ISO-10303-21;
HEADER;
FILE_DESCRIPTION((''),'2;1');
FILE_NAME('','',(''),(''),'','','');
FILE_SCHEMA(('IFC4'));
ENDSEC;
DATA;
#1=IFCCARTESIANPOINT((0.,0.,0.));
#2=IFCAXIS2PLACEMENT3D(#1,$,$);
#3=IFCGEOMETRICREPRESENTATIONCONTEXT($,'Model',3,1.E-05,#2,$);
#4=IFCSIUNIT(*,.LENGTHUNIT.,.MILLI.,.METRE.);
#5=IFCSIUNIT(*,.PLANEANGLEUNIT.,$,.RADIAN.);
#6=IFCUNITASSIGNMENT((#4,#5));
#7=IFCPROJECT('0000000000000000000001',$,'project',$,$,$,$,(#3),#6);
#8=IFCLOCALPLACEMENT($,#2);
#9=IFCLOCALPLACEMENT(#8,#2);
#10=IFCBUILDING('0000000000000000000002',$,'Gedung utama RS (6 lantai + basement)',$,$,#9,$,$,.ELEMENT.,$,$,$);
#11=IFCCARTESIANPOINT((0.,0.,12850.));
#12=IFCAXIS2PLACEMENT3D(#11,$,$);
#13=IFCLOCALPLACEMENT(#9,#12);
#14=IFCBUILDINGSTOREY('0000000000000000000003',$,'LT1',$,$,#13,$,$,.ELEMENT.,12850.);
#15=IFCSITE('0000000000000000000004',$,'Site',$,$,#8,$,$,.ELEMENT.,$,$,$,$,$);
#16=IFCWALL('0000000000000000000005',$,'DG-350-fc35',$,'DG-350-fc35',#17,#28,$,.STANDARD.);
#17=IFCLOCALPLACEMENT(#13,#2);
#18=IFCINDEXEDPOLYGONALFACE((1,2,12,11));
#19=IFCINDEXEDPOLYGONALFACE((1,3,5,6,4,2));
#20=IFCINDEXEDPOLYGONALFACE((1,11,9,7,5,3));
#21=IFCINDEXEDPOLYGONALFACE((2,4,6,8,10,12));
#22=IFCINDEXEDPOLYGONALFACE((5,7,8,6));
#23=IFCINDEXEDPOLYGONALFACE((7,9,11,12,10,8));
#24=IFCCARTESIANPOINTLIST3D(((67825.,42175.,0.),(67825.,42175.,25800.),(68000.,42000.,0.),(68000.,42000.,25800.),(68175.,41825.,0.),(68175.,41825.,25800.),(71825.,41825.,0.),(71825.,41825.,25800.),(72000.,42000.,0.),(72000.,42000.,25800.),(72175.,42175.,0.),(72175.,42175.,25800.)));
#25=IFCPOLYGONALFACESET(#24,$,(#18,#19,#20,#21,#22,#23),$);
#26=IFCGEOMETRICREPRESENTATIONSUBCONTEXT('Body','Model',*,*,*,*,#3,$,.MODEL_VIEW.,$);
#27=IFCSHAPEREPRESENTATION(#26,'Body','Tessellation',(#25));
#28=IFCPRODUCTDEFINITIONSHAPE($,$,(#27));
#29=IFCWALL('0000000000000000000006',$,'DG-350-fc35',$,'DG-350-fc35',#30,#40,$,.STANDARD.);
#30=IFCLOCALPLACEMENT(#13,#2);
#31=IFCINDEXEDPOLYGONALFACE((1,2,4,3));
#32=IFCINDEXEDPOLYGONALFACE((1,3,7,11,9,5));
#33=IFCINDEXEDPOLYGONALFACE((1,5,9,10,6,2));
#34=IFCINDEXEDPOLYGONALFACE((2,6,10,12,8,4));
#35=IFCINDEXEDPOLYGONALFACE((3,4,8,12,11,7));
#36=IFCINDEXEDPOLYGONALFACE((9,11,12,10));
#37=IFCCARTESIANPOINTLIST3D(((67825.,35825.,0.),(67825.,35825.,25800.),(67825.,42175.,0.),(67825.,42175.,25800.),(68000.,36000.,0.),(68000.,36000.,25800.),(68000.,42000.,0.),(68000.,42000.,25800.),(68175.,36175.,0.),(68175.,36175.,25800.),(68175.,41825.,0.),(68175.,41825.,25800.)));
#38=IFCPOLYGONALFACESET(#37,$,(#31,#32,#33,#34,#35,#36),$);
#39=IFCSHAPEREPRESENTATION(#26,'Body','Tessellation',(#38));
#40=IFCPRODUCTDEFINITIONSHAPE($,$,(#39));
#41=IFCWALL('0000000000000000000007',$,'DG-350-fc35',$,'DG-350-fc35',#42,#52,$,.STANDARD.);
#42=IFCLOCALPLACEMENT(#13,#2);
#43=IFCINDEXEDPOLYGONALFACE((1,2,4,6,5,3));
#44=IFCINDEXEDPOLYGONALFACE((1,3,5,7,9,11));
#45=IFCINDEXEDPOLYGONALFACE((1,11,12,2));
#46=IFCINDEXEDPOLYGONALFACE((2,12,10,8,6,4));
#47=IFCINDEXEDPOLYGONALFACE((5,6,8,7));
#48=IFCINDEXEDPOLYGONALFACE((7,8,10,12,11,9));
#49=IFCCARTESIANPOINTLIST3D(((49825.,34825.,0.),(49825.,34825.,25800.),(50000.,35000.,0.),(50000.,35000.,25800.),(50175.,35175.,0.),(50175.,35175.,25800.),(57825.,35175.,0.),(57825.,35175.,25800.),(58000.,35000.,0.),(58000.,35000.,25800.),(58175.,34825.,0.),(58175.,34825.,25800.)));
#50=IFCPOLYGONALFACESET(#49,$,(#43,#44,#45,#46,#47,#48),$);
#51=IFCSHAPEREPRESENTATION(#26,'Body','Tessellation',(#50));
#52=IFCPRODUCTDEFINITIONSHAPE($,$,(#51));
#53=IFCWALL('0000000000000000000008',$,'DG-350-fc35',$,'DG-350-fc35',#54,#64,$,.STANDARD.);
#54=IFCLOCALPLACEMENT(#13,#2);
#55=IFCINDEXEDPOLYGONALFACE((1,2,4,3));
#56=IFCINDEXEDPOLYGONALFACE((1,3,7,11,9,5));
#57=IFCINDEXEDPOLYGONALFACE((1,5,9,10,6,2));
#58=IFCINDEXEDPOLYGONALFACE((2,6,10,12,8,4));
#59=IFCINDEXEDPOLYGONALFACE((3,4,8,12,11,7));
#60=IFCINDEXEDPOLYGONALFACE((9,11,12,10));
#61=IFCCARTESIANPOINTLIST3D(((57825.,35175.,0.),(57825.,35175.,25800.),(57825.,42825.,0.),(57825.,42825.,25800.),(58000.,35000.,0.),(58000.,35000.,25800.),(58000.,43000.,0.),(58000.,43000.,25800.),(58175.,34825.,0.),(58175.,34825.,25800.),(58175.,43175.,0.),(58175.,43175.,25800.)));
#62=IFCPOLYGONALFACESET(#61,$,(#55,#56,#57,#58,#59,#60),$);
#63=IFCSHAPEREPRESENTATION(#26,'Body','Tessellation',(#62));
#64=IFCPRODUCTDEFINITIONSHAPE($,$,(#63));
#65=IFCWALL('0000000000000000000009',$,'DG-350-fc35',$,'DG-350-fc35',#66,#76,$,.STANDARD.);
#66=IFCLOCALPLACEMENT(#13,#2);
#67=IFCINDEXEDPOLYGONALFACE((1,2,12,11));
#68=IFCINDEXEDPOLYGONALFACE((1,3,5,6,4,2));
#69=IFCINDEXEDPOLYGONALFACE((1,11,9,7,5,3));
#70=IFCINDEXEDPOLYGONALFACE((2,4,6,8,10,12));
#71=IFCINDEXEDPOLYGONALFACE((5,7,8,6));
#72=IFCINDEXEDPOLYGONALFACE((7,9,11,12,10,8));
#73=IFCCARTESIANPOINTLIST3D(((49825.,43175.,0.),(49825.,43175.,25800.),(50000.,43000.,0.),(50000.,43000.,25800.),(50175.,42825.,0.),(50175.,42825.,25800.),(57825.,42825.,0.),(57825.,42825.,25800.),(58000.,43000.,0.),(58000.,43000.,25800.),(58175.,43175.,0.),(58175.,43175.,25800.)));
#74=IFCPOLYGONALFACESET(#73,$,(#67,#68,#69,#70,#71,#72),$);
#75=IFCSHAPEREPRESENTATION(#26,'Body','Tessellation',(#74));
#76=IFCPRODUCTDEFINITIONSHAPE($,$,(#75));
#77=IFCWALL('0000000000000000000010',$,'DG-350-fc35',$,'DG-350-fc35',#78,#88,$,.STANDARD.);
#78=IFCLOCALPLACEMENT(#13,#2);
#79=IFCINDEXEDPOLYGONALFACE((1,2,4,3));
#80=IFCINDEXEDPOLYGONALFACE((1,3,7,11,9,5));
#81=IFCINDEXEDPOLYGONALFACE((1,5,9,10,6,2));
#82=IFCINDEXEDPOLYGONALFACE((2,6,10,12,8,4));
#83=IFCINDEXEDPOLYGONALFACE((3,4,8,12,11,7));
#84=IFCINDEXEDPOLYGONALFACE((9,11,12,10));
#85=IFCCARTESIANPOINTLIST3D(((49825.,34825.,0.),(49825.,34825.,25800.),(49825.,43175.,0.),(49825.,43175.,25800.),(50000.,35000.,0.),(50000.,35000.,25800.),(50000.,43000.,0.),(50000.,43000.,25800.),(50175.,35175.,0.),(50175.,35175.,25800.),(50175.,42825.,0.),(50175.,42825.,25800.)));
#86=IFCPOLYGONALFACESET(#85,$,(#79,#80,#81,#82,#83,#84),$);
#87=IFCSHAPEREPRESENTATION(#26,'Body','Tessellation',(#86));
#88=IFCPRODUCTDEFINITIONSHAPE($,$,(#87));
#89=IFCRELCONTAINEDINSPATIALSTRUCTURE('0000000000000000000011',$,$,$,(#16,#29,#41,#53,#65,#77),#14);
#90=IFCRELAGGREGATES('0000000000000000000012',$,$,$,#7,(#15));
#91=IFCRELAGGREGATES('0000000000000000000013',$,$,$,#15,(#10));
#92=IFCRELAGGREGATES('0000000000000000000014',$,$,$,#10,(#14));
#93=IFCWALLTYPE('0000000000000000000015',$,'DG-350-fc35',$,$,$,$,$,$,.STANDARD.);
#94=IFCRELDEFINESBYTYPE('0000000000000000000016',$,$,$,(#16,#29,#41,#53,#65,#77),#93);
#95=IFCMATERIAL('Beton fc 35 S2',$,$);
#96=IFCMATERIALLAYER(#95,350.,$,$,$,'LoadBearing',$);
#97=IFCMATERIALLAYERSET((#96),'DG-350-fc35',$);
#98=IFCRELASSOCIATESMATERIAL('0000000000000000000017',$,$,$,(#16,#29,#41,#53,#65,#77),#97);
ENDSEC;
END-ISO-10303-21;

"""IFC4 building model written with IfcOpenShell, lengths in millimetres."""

from ifc_helpers import new_model, si_unit, frame, origin, place, context, subcontext, project, spatial, polyline, outline, extrude, material, layer, layer_set, layer_usage, type_object, element, save


model = new_model("IFC4")

# Units and contexts
model_context = context("Model", 3, precision=1e-05, world=origin())
body_context = subcontext(model_context, "Body", "Model", "MODEL_VIEW")
ifc_project = project(units=[si_unit("LENGTHUNIT", "METRE", prefix="MILLI"), si_unit("PLANEANGLEUNIT", "RADIAN")], contexts=[model_context])

# Site, building, storey
site_placement = place(None, origin())
site = spatial("IfcSite", under=ifc_project, at=site_placement, Name="Site", CompositionType="ELEMENT")
building_placement = place(site_placement, origin())
building = spatial("IfcBuilding", under=site, at=building_placement, Name="Gedung utama RS (6 lantai + basement)", CompositionType="ELEMENT")
storey_placement = place(building_placement, frame((0.0, 0.0, 12850.0)))
storey = spatial("IfcBuildingStorey", under=building, at=storey_placement, Name="LT1", CompositionType="ELEMENT", Elevation=12850.0)

# Walls
ifc_material = material(Name="Beton fc 35 S2")
ifc_layer = layer(ifc_material, 350.0, Category="LoadBearing")
ifc_layer_set = layer_set([ifc_layer], Name="DG-350-fc35")
ifc_layer_usage = layer_usage(ifc_layer_set, "AXIS2", "NEGATIVE", 175.0)
wall_type = type_object("IfcWallType", Name="DG-350-fc35", PredefinedType="STANDARD")
wall_1_placement = place(storey_placement, frame((72000.0, 42000.0, 0.0), z_axis=(0.0, 0.0, 1.0), x_axis=(-1.0, 0.0, 0.0)))
element("IfcWall", 1, at=wall_1_placement, inside=storey, type_object=wall_type, material=ifc_layer_usage, Name="DG-350-fc35", ObjectType="DG-350-fc35", PredefinedType="STANDARD", context=body_context, shape_type="SweptSolid", body=[
    extrude(outline(polyline([(-175.0, -175.0), (0.0, 0.0), (175.0, 175.0), (3825.0, 175.0), (4000.0, 0.0), (4175.0, -175.0), (-175.0, -175.0)])), origin(), (0.0, 0.0, 1.0), 25800.0),
])
wall_2_placement = place(storey_placement, frame((68000.0, 42000.0, 0.0), z_axis=(0.0, 0.0, 1.0), x_axis=(0.0, -1.0, 0.0)))
element("IfcWall", 2, at=wall_2_placement, inside=storey, type_object=wall_type, material=ifc_layer_usage, Name="DG-350-fc35", ObjectType="DG-350-fc35", PredefinedType="STANDARD", context=body_context, shape_type="SweptSolid", body=[
    extrude(outline(polyline([(-175.0, -175.0), (0.0, 0.0), (175.0, 175.0), (5825.0, 175.0), (6000.0, 0.0), (6175.0, -175.0), (-175.0, -175.0)])), origin(), (0.0, 0.0, 1.0), 25800.0),
])
for number, where, z_axis, x_axis, name in (
    (3, (50000.0, 35000.0, 0.0), (0.0, 0.0, 1.0), (1.0, 0.0, 0.0), "DG-350-fc35"),
    (4, (58000.0, 35000.0, 0.0), (0.0, 0.0, 1.0), (0.0, 1.0, 0.0), "DG-350-fc35"),
    (5, (58000.0, 43000.0, 0.0), (0.0, 0.0, 1.0), (-1.0, 0.0, 0.0), "DG-350-fc35"),
    (6, (50000.0, 43000.0, 0.0), (0.0, 0.0, 1.0), (0.0, -1.0, 0.0), "DG-350-fc35"),
):
    element("IfcWall", number, at=place(storey_placement, frame(where, z_axis=z_axis, x_axis=x_axis)), inside=storey, type_object=wall_type, material=ifc_layer_usage, Name=name, ObjectType="DG-350-fc35", PredefinedType="STANDARD", context=body_context, shape_type="SweptSolid", body=[
        extrude(outline(polyline([(-175.0, -175.0), (0.0, 0.0), (175.0, 175.0), (7825.0, 175.0), (8000.0, 0.0), (8175.0, -175.0), (-175.0, -175.0)])), origin(), (0.0, 0.0, 1.0), 25800.0),
    ])

save(model, "model.ifc")
